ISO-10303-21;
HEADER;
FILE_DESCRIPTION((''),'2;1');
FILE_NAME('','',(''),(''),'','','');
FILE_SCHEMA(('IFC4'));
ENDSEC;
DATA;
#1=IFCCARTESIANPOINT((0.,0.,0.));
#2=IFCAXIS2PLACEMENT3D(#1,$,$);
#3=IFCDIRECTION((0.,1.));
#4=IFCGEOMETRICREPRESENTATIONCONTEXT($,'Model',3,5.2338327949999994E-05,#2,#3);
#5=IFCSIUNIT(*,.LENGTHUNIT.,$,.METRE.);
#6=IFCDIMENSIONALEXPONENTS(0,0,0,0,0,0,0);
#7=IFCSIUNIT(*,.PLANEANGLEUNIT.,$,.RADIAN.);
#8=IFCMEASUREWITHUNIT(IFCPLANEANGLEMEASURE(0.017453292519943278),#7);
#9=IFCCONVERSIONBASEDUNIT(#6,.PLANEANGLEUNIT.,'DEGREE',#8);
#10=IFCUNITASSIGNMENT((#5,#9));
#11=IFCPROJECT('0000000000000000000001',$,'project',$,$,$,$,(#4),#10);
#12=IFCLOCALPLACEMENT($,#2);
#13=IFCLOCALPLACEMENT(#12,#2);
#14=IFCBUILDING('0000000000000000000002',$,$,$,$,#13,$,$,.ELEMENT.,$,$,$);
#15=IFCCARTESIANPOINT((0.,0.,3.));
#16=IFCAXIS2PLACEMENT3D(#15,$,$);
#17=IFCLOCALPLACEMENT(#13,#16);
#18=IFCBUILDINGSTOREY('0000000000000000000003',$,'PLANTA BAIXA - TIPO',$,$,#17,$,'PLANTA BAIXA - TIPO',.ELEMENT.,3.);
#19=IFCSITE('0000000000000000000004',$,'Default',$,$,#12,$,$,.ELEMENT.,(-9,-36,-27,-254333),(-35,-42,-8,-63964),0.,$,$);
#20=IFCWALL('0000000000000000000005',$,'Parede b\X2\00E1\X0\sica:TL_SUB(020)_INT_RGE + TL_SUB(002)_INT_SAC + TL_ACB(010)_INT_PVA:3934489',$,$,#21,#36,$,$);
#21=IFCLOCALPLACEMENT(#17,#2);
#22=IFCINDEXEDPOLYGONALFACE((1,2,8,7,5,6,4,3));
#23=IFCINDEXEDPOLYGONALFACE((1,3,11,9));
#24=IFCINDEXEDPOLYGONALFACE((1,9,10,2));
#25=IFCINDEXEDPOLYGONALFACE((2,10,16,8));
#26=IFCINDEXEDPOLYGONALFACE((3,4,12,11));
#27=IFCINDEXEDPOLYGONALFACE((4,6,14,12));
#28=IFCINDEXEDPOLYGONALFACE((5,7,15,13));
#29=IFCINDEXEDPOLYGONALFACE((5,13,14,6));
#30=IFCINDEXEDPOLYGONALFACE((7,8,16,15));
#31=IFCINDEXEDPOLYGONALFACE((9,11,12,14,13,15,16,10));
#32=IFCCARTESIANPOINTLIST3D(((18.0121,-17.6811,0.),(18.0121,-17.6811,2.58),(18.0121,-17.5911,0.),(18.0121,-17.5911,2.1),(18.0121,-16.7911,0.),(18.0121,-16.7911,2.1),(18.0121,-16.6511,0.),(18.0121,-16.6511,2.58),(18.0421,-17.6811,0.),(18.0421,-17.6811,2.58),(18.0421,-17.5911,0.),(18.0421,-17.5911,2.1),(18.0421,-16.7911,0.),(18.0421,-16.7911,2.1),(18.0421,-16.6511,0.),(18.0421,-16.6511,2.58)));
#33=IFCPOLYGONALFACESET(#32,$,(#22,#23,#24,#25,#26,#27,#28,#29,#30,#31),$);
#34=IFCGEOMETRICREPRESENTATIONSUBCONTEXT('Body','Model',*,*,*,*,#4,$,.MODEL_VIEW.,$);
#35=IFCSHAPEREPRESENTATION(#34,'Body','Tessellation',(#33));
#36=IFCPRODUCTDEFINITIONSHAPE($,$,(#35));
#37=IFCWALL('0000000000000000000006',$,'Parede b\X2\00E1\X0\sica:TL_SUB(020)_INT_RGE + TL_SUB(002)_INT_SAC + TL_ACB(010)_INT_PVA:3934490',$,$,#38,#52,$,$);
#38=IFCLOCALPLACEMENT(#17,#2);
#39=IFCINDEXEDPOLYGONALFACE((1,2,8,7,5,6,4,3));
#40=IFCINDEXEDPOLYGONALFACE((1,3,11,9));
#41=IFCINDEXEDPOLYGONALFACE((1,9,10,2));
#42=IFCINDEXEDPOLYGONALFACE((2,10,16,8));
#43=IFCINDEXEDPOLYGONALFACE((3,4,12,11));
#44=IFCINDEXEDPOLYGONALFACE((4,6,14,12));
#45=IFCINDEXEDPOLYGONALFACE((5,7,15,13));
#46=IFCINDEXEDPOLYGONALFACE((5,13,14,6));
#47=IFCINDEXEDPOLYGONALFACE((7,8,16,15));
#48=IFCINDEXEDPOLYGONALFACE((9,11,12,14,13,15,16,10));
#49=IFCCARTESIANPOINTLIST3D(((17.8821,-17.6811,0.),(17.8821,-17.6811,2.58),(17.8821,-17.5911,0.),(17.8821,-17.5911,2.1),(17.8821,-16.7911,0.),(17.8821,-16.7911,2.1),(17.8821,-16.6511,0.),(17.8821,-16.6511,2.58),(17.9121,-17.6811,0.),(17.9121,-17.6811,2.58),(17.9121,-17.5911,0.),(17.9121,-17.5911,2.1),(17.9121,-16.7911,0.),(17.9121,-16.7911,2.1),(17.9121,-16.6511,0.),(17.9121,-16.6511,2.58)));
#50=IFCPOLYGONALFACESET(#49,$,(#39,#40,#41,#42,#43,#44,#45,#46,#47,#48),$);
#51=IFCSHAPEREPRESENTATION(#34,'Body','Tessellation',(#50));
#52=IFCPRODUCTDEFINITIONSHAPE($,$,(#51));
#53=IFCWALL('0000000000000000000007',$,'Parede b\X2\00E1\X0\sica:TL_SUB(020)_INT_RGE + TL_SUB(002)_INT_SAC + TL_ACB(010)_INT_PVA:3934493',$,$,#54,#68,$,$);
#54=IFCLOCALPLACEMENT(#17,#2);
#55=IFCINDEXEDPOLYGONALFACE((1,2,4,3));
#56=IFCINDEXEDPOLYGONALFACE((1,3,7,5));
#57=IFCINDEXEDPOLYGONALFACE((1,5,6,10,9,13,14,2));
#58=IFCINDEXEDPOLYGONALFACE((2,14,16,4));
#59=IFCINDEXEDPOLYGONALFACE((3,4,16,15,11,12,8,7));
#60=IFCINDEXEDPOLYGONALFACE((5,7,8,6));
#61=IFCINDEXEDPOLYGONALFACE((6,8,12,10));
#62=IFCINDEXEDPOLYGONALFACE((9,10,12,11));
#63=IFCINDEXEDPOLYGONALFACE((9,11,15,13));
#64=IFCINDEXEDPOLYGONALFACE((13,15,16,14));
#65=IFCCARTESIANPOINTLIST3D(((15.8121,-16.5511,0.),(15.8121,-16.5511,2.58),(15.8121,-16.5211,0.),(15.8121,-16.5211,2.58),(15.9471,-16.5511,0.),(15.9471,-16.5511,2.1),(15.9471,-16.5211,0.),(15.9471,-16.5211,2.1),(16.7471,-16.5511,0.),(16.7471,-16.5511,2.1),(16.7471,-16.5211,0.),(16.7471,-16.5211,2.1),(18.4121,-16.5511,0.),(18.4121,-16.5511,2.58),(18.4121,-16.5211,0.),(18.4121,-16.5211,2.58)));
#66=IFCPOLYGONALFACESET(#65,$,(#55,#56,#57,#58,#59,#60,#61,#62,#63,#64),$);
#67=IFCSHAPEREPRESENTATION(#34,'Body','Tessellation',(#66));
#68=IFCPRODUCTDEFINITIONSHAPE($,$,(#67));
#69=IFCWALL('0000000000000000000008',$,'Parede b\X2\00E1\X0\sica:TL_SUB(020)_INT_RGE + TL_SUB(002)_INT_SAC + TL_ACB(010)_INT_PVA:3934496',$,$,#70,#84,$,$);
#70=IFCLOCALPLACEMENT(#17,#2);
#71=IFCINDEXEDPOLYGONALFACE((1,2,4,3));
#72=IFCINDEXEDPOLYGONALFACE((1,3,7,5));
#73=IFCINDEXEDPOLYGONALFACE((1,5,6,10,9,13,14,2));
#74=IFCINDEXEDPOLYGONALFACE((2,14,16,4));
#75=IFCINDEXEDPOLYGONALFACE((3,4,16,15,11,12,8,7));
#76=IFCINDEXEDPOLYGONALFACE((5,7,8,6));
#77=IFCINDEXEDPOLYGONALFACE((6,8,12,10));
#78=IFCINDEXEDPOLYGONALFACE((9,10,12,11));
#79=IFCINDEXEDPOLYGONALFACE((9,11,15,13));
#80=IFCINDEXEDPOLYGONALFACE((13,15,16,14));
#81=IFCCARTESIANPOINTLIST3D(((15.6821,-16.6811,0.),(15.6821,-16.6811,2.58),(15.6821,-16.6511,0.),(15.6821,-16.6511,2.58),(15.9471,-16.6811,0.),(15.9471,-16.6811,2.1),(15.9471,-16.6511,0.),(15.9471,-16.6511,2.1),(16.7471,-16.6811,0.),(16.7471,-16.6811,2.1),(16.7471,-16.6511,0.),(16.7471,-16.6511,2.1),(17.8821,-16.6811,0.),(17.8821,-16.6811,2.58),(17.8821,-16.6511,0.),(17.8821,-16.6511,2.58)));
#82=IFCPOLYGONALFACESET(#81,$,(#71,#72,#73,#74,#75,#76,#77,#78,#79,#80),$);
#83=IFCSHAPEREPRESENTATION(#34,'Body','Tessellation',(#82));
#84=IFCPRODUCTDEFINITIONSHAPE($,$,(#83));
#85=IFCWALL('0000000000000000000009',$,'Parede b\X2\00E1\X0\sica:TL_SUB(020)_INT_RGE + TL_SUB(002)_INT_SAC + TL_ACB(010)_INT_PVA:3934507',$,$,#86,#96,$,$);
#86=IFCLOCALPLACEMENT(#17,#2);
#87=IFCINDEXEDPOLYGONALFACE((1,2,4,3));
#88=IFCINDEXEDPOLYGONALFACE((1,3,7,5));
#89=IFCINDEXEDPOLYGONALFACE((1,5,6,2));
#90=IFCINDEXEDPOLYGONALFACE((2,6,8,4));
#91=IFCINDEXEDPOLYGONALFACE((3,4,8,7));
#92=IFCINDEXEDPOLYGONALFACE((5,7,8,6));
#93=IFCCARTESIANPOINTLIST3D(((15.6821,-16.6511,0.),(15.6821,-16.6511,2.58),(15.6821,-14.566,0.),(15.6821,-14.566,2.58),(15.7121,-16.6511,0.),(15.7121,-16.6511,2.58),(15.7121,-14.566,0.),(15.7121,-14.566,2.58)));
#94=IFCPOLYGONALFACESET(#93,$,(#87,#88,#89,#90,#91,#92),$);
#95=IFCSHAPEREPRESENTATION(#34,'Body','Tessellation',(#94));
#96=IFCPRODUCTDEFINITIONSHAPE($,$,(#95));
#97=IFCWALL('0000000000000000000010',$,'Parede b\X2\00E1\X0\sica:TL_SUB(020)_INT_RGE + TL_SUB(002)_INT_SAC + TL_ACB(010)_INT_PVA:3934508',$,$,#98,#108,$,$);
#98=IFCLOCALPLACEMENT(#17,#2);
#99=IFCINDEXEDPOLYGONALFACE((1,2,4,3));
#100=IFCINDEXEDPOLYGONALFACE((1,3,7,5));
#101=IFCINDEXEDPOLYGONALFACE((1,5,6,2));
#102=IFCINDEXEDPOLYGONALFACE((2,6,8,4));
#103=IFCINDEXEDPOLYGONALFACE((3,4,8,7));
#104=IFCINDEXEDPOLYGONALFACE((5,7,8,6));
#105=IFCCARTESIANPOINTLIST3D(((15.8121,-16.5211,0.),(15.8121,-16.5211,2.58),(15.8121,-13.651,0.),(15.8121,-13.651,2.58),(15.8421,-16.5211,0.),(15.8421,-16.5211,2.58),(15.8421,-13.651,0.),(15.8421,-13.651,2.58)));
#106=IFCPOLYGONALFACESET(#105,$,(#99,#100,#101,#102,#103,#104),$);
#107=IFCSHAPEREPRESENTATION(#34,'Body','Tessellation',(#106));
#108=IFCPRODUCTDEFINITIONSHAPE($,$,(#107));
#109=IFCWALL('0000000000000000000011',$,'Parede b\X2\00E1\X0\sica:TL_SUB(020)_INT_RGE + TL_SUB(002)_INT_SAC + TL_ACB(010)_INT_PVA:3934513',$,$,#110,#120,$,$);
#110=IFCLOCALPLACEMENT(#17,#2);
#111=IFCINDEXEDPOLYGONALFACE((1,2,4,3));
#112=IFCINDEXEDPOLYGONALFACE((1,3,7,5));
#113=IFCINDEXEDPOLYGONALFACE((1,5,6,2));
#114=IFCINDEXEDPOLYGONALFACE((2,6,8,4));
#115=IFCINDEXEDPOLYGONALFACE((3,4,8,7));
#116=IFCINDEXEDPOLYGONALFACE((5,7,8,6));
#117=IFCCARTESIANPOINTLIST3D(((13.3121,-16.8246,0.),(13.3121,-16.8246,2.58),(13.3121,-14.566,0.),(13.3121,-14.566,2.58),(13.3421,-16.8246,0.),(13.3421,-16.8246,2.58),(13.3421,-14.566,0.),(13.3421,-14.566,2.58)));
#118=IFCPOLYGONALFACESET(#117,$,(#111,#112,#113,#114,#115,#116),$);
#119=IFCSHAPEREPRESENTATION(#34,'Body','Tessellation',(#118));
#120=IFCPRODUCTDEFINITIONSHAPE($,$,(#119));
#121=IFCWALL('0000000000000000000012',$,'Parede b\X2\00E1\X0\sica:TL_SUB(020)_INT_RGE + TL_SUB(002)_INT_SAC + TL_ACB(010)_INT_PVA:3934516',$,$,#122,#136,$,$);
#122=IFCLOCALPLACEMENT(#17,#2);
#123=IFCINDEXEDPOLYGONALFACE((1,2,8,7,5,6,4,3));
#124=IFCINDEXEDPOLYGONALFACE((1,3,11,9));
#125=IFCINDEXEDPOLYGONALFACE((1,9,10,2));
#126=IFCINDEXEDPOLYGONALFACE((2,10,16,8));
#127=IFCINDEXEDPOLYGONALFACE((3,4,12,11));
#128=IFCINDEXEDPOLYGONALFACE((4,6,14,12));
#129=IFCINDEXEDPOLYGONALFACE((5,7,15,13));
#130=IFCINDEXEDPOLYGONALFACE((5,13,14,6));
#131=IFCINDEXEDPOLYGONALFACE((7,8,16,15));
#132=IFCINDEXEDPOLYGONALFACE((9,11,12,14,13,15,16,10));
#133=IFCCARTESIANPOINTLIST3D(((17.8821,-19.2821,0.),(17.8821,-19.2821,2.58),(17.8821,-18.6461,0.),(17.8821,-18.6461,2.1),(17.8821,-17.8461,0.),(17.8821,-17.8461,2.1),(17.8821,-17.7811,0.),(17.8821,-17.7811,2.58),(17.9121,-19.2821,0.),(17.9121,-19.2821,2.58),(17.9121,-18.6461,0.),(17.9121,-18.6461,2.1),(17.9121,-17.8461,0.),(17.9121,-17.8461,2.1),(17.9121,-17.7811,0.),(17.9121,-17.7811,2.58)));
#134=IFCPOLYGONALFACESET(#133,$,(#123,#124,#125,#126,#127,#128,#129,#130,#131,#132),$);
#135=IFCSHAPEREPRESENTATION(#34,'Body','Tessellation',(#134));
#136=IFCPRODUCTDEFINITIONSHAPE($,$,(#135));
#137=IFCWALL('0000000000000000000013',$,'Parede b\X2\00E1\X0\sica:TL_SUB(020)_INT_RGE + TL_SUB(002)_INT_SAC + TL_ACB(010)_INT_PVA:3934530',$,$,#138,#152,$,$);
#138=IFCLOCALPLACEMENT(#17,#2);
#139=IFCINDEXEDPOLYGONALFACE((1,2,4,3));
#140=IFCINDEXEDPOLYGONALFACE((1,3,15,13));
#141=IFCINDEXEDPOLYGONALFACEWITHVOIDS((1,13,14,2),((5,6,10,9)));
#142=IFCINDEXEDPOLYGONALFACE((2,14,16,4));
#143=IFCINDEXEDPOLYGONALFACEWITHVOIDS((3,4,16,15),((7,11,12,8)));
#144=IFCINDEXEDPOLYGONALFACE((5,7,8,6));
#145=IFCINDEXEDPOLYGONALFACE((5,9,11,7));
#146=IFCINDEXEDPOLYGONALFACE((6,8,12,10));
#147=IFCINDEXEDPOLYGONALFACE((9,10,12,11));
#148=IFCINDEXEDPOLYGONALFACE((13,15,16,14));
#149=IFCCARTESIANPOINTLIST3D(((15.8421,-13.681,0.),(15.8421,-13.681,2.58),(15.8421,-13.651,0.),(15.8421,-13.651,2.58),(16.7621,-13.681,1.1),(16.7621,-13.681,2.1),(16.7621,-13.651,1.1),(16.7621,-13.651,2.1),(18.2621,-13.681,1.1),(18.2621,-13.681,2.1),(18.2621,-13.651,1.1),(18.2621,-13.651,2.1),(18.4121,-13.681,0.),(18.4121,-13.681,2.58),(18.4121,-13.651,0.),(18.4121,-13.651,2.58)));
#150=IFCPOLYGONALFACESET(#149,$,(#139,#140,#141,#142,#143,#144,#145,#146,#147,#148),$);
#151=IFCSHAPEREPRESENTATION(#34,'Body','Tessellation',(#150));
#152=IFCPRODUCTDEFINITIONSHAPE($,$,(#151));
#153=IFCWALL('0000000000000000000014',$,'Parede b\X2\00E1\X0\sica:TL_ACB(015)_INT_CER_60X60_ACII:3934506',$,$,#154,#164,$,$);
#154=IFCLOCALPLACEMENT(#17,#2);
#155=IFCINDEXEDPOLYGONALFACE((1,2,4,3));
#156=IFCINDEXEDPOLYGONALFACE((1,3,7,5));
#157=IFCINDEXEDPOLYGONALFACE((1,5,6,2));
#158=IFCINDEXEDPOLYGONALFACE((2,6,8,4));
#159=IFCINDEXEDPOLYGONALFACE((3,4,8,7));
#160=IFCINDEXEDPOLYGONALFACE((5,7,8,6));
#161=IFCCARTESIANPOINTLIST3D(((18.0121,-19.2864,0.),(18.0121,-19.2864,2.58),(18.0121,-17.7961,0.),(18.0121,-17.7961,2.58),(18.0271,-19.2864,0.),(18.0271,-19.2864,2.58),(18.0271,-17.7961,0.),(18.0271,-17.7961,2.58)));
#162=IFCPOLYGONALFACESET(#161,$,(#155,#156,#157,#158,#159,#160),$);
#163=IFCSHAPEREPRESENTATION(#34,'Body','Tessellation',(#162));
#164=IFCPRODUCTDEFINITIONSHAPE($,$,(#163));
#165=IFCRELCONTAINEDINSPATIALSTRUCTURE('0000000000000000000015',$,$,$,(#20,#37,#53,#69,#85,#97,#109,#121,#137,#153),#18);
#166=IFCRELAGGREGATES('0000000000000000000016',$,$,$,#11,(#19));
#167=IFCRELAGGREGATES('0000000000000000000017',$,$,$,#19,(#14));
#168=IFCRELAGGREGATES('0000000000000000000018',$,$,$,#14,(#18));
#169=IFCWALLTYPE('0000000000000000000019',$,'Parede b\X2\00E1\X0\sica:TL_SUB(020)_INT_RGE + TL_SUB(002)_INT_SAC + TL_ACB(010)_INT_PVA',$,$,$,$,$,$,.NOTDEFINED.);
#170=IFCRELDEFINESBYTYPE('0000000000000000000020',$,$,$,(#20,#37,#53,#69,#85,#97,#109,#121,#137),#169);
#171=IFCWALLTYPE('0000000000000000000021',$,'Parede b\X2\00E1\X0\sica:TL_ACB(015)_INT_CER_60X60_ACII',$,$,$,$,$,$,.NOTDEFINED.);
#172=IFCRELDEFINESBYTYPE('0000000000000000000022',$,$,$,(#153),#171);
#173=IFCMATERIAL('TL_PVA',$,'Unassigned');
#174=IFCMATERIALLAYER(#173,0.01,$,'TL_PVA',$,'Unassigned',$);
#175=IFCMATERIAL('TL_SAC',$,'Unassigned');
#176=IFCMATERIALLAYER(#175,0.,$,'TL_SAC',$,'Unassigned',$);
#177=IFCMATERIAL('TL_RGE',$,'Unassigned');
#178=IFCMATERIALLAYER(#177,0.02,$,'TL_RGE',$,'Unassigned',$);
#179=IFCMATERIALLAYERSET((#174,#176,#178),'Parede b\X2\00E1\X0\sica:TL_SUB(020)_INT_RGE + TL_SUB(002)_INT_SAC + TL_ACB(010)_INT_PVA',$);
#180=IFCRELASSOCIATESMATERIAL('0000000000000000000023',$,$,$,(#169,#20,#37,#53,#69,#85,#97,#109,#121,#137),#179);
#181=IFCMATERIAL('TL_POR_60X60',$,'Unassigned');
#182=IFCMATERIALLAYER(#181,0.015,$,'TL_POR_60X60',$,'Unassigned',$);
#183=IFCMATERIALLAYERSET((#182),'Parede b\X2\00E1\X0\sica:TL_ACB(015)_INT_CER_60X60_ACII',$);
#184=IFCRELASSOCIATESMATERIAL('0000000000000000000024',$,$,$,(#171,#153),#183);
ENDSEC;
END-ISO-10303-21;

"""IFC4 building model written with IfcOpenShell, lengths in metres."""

from ifc_helpers import new_model, entity, si_unit, converted_unit, direction, frame, frame_2d, origin, place, context, subcontext, project, spatial, rectangle, extrude, material, layer, layer_set, layer_usage, type_object, element, save


model = new_model("IFC4")

# Units and contexts
model_context = context("Model", 3, precision=5.2338327949999994e-05, world=origin(), true_north=direction((0.0, 1.0)))
body_context = subcontext(model_context, "Body", "Model", "MODEL_VIEW")
ifc_project = project(units=[si_unit("LENGTHUNIT", "METRE"), converted_unit("PLANEANGLEUNIT", "DEGREE", entity("IfcPlaneAngleMeasure", 0.017453292519943278), si_unit("PLANEANGLEUNIT", "RADIAN"), dimensions=[0, 0, 0, 0, 0, 0, 0])], contexts=[model_context])

# Site, building, storey
site_placement = place(None, frame((0.0, 0.0, 0.0)))
site = spatial("IfcSite", under=ifc_project, at=site_placement, Name="Default", CompositionType="ELEMENT", RefLatitude=(-9, -36, -27, -254333), RefLongitude=(-35, -42, -8, -63964), RefElevation=0.0)
building_placement = place(site_placement, origin())
building = spatial("IfcBuilding", under=site, at=building_placement, CompositionType="ELEMENT")
storey_placement = place(building_placement, frame((0.0, 0.0, 3.0)))
storey = spatial("IfcBuildingStorey", under=building, at=storey_placement, Name="PLANTA BAIXA - TIPO", LongName="PLANTA BAIXA - TIPO", CompositionType="ELEMENT", Elevation=3.0)

# Walls, openings
ifc_material_1 = material(Name="TL_PVA", Category="Unassigned")
ifc_layer_1 = layer(ifc_material_1, 0.01, Name="TL_PVA", Category="Unassigned")
ifc_material_2 = material(Name="TL_SAC", Category="Unassigned")
ifc_layer_2 = layer(ifc_material_2, 0.0, Name="TL_SAC", Category="Unassigned")
ifc_material_3 = material(Name="TL_RGE", Category="Unassigned")
ifc_layer_3 = layer(ifc_material_3, 0.02, Name="TL_RGE", Category="Unassigned")
ifc_layer_set_1 = layer_set([ifc_layer_1, ifc_layer_2, ifc_layer_3], Name="Parede básica:TL_SUB(020)_INT_RGE + TL_SUB(002)_INT_SAC + TL_ACB(010)_INT_PVA")
ifc_layer_usage_1 = layer_usage(ifc_layer_set_1, "AXIS2", "NEGATIVE", 0.015)
wall_type_1 = type_object("IfcWallType", Name="Parede básica:TL_SUB(020)_INT_RGE + TL_SUB(002)_INT_SAC + TL_ACB(010)_INT_PVA", PredefinedType="NOTDEFINED", material=ifc_layer_set_1)
wall_1_placement = place(storey_placement, frame((18.0271, -16.6511, 0.0), z_axis=(0.0, 0.0, 1.0), x_axis=(0.0, -1.0, 0.0)))
wall_1 = element("IfcWall", 1, at=wall_1_placement, inside=storey, type_object=wall_type_1, material=ifc_layer_usage_1, Name="Parede básica:TL_SUB(020)_INT_RGE + TL_SUB(002)_INT_SAC + TL_ACB(010)_INT_PVA:3934489", context=body_context, shape_type="SweptSolid", body=[
    extrude(rectangle(XDim=1.03, YDim=0.03, at=frame_2d((0.515, 0.0), x_axis=(-1.0, 0.0))), origin(), (0.0, 0.0, 1.0), 2.58),
])
opening_1_placement = place(wall_1_placement, frame((-16.6511, -18.0271, 0.0)))
element("IfcOpeningElement", 2, at=opening_1_placement, cuts=wall_1, PredefinedType="OPENING", context=body_context, shape_type="SweptSolid", body=[
    extrude(rectangle(XDim=2.1, YDim=0.8, at=frame_2d((0.0, 0.0), x_axis=(0.0, 1.0))), frame((17.1911, 16.3881, 1.05), z_axis=(0.0, 1.0, 0.0), x_axis=(-1.0, 0.0, 0.0)), (0.0, 0.0, 1.0), 3.048),
])
ifc_layer_usage_2 = layer_usage(ifc_layer_set_1, "AXIS2", "NEGATIVE", 0.015)
wall_2_placement = place(storey_placement, frame((17.8971, -17.6811, 0.0), z_axis=(0.0, 0.0, 1.0), x_axis=(0.0, 1.0, 0.0)))
wall_2 = element("IfcWall", 3, at=wall_2_placement, inside=storey, type_object=wall_type_1, material=ifc_layer_usage_2, Name="Parede básica:TL_SUB(020)_INT_RGE + TL_SUB(002)_INT_SAC + TL_ACB(010)_INT_PVA:3934490", context=body_context, shape_type="SweptSolid", body=[
    extrude(rectangle(XDim=1.03, YDim=0.03, at=frame_2d((0.515, 0.0), x_axis=(-1.0, 0.0))), origin(), (0.0, 0.0, 1.0), 2.58),
])
opening_2_placement = place(wall_2_placement, frame((17.6811, 17.8971, 0.0)))
element("IfcOpeningElement", 4, at=opening_2_placement, cuts=wall_2, PredefinedType="OPENING", context=body_context, shape_type="SweptSolid", body=[
    extrude(rectangle(XDim=2.1, YDim=0.8, at=frame_2d((0.0, 0.0), x_axis=(1.0, 0.0))), frame((-17.1911, -19.4361, 1.05), z_axis=(0.0, 1.0, 0.0), x_axis=(0.0, 0.0, 1.0)), (0.0, 0.0, 1.0), 3.048),
])
ifc_layer_usage_3 = layer_usage(ifc_layer_set_1, "AXIS2", "NEGATIVE", 0.015)
wall_3_placement = place(storey_placement, frame((15.8121, -16.5361, 0.0)))
wall_3 = element("IfcWall", 5, at=wall_3_placement, inside=storey, type_object=wall_type_1, material=ifc_layer_usage_3, Name="Parede básica:TL_SUB(020)_INT_RGE + TL_SUB(002)_INT_SAC + TL_ACB(010)_INT_PVA:3934493", context=body_context, shape_type="SweptSolid", body=[
    extrude(rectangle(XDim=2.6, YDim=0.03, at=frame_2d((1.3, 0.0), x_axis=(-1.0, 0.0))), origin(), (0.0, 0.0, 1.0), 2.58),
])
opening_3_placement = place(wall_3_placement, frame((-15.8121, 16.5361, 0.0)))
element("IfcOpeningElement", 6, at=opening_3_placement, cuts=wall_3, PredefinedType="OPENING", context=body_context, shape_type="SweptSolid", body=[
    extrude(rectangle(XDim=2.1, YDim=0.8, at=frame_2d((0.0, 0.0), x_axis=(1.0, 0.0))), frame((16.3471, -18.1751, 1.05), z_axis=(0.0, 1.0, 0.0), x_axis=(0.0, 0.0, 1.0)), (0.0, 0.0, 1.0), 3.048),
])
ifc_layer_usage_4 = layer_usage(ifc_layer_set_1, "AXIS2", "NEGATIVE", 0.015)
wall_4_placement = place(storey_placement, frame((17.8821, -16.6661, 0.0), z_axis=(0.0, 0.0, 1.0), x_axis=(-1.0, 0.0, 0.0)))
wall_4 = element("IfcWall", 7, at=wall_4_placement, inside=storey, type_object=wall_type_1, material=ifc_layer_usage_4, Name="Parede básica:TL_SUB(020)_INT_RGE + TL_SUB(002)_INT_SAC + TL_ACB(010)_INT_PVA:3934496", context=body_context, shape_type="SweptSolid", body=[
    extrude(rectangle(XDim=2.2, YDim=0.03, at=frame_2d((1.1, 0.0), x_axis=(-1.0, 0.0))), origin(), (0.0, 0.0, 1.0), 2.58),
])
opening_4_placement = place(wall_4_placement, frame((17.8821, -16.6661, 0.0)))
element("IfcOpeningElement", 8, at=opening_4_placement, cuts=wall_4, PredefinedType="OPENING", context=body_context, shape_type="SweptSolid", body=[
    extrude(rectangle(XDim=2.1, YDim=0.8, at=frame_2d((0.0, 0.0), x_axis=(0.0, 1.0))), frame((-16.3471, 15.1271, 1.05), z_axis=(0.0, 1.0, 0.0), x_axis=(-1.0, 0.0, 0.0)), (0.0, 0.0, 1.0), 3.048),
])

# Walls
ifc_layer_usage_5 = layer_usage(ifc_layer_set_1, "AXIS2", "POSITIVE", -0.015)
wall_5_placement = place(storey_placement, frame((15.6971, -14.566, 0.0), z_axis=(0.0, 0.0, 1.0), x_axis=(0.0, -1.0, 0.0)))
element("IfcWall", 9, at=wall_5_placement, inside=storey, type_object=wall_type_1, material=ifc_layer_usage_5, Name="Parede básica:TL_SUB(020)_INT_RGE + TL_SUB(002)_INT_SAC + TL_ACB(010)_INT_PVA:3934507", context=body_context, shape_type="SweptSolid", body=[
    extrude(rectangle(XDim=2.0851, YDim=0.03, at=frame_2d((1.0426, 0.0), x_axis=(-1.0, 0.0))), origin(), (0.0, 0.0, 1.0), 2.58),
])
ifc_layer_usage_6 = layer_usage(ifc_layer_set_1, "AXIS2", "POSITIVE", -0.015)
wall_6_placement = place(storey_placement, frame((15.8271, -16.5211, 0.0), z_axis=(0.0, 0.0, 1.0), x_axis=(0.0, 1.0, 0.0)))
element("IfcWall", 10, at=wall_6_placement, inside=storey, type_object=wall_type_1, material=ifc_layer_usage_6, Name="Parede básica:TL_SUB(020)_INT_RGE + TL_SUB(002)_INT_SAC + TL_ACB(010)_INT_PVA:3934508", context=body_context, shape_type="SweptSolid", body=[
    extrude(rectangle(XDim=2.8701, YDim=0.03, at=frame_2d((1.4351, 0.0), x_axis=(-1.0, 0.0))), origin(), (0.0, 0.0, 1.0), 2.58),
])
ifc_layer_usage_7 = layer_usage(ifc_layer_set_1, "AXIS2", "POSITIVE", -0.015)
wall_7_placement = place(storey_placement, frame((13.3271, -16.8246, 0.0), z_axis=(0.0, 0.0, 1.0), x_axis=(0.0, 1.0, 0.0)))
element("IfcWall", 11, at=wall_7_placement, inside=storey, type_object=wall_type_1, material=ifc_layer_usage_7, Name="Parede básica:TL_SUB(020)_INT_RGE + TL_SUB(002)_INT_SAC + TL_ACB(010)_INT_PVA:3934513", context=body_context, shape_type="SweptSolid", body=[
    extrude(rectangle(XDim=2.2587, YDim=0.03, at=frame_2d((1.1293, 0.0), x_axis=(-1.0, 0.0))), origin(), (0.0, 0.0, 1.0), 2.58),
])

# Walls, openings
ifc_layer_usage_8 = layer_usage(ifc_layer_set_1, "AXIS2", "POSITIVE", -0.015)
wall_8_placement = place(storey_placement, frame((17.8971, -17.7811, 0.0), z_axis=(0.0, 0.0, 1.0), x_axis=(0.0, -1.0, 0.0)))
wall_8 = element("IfcWall", 12, at=wall_8_placement, inside=storey, type_object=wall_type_1, material=ifc_layer_usage_8, Name="Parede básica:TL_SUB(020)_INT_RGE + TL_SUB(002)_INT_SAC + TL_ACB(010)_INT_PVA:3934516", context=body_context, shape_type="SweptSolid", body=[
    extrude(rectangle(XDim=1.501, YDim=0.03, at=frame_2d((0.7505, 0.0), x_axis=(-1.0, 0.0))), origin(), (0.0, 0.0, 1.0), 2.58),
])
opening_5_placement = place(wall_8_placement, frame((0.065, -0.015, 0.0)))
element("IfcOpeningElement", 13, at=opening_5_placement, cuts=wall_8, PredefinedType="OPENING", context=body_context, shape_type="SweptSolid", body=[
    extrude(rectangle(XDim=2.1, YDim=0.8, at=frame_2d((1.05, 0.4), x_axis=(1.0, 0.0))), frame((0.0, 0.0, 0.0), z_axis=(0.0, 1.0, 0.0), x_axis=(0.0, 0.0, 1.0)), (0.0, 0.0, 1.0), 0.03),
])
ifc_layer_usage_9 = layer_usage(ifc_layer_set_1, "AXIS2", "POSITIVE", -0.015)
wall_9_placement = place(storey_placement, frame((15.8421, -13.666, 0.0)))
wall_9 = element("IfcWall", 14, at=wall_9_placement, inside=storey, type_object=wall_type_1, material=ifc_layer_usage_9, Name="Parede básica:TL_SUB(020)_INT_RGE + TL_SUB(002)_INT_SAC + TL_ACB(010)_INT_PVA:3934530", context=body_context, shape_type="SweptSolid", body=[
    extrude(rectangle(XDim=2.57, YDim=0.03, at=frame_2d((1.285, 0.0), x_axis=(-1.0, 0.0))), origin(), (0.0, 0.0, 1.0), 2.58),
])
opening_6_placement = place(wall_9_placement, frame((-15.8421, 13.666, 1.1)))
element("IfcOpeningElement", 15, at=opening_6_placement, cuts=wall_9, PredefinedType="OPENING", context=body_context, shape_type="SweptSolid", body=[
    extrude(rectangle(XDim=1.0, YDim=1.5, at=frame_2d((0.0, 0.0), x_axis=(0.0, 1.0))), frame((17.5121, -15.175, 0.5), z_axis=(0.0, 1.0, 0.0), x_axis=(1.0, 0.0, 0.0)), (0.0, 0.0, 1.0), 3.048),
])

# Wall
ifc_material_4 = material(Name="TL_POR_60X60", Category="Unassigned")
ifc_layer_4 = layer(ifc_material_4, 0.015, Name="TL_POR_60X60", Category="Unassigned")
ifc_layer_set_2 = layer_set([ifc_layer_4], Name="Parede básica:TL_ACB(015)_INT_CER_60X60_ACII")
ifc_layer_usage_10 = layer_usage(ifc_layer_set_2, "AXIS2", "POSITIVE", -0.0075)
wall_type_2 = type_object("IfcWallType", Name="Parede básica:TL_ACB(015)_INT_CER_60X60_ACII", PredefinedType="NOTDEFINED", material=ifc_layer_set_2)
wall_10_placement = place(storey_placement, frame((18.0196, -19.2864, 0.0), z_axis=(0.0, 0.0, 1.0), x_axis=(0.0, 1.0, 0.0)))
element("IfcWall", 16, at=wall_10_placement, inside=storey, type_object=wall_type_2, material=ifc_layer_usage_10, Name="Parede básica:TL_ACB(015)_INT_CER_60X60_ACII:3934506", context=body_context, shape_type="SweptSolid", body=[
    extrude(rectangle(XDim=1.4902, YDim=0.015, at=frame_2d((0.7451, 0.0), x_axis=(-1.0, 0.0))), origin(), (0.0, 0.0, 1.0), 2.58),
])

save(model, "model.ifc")
